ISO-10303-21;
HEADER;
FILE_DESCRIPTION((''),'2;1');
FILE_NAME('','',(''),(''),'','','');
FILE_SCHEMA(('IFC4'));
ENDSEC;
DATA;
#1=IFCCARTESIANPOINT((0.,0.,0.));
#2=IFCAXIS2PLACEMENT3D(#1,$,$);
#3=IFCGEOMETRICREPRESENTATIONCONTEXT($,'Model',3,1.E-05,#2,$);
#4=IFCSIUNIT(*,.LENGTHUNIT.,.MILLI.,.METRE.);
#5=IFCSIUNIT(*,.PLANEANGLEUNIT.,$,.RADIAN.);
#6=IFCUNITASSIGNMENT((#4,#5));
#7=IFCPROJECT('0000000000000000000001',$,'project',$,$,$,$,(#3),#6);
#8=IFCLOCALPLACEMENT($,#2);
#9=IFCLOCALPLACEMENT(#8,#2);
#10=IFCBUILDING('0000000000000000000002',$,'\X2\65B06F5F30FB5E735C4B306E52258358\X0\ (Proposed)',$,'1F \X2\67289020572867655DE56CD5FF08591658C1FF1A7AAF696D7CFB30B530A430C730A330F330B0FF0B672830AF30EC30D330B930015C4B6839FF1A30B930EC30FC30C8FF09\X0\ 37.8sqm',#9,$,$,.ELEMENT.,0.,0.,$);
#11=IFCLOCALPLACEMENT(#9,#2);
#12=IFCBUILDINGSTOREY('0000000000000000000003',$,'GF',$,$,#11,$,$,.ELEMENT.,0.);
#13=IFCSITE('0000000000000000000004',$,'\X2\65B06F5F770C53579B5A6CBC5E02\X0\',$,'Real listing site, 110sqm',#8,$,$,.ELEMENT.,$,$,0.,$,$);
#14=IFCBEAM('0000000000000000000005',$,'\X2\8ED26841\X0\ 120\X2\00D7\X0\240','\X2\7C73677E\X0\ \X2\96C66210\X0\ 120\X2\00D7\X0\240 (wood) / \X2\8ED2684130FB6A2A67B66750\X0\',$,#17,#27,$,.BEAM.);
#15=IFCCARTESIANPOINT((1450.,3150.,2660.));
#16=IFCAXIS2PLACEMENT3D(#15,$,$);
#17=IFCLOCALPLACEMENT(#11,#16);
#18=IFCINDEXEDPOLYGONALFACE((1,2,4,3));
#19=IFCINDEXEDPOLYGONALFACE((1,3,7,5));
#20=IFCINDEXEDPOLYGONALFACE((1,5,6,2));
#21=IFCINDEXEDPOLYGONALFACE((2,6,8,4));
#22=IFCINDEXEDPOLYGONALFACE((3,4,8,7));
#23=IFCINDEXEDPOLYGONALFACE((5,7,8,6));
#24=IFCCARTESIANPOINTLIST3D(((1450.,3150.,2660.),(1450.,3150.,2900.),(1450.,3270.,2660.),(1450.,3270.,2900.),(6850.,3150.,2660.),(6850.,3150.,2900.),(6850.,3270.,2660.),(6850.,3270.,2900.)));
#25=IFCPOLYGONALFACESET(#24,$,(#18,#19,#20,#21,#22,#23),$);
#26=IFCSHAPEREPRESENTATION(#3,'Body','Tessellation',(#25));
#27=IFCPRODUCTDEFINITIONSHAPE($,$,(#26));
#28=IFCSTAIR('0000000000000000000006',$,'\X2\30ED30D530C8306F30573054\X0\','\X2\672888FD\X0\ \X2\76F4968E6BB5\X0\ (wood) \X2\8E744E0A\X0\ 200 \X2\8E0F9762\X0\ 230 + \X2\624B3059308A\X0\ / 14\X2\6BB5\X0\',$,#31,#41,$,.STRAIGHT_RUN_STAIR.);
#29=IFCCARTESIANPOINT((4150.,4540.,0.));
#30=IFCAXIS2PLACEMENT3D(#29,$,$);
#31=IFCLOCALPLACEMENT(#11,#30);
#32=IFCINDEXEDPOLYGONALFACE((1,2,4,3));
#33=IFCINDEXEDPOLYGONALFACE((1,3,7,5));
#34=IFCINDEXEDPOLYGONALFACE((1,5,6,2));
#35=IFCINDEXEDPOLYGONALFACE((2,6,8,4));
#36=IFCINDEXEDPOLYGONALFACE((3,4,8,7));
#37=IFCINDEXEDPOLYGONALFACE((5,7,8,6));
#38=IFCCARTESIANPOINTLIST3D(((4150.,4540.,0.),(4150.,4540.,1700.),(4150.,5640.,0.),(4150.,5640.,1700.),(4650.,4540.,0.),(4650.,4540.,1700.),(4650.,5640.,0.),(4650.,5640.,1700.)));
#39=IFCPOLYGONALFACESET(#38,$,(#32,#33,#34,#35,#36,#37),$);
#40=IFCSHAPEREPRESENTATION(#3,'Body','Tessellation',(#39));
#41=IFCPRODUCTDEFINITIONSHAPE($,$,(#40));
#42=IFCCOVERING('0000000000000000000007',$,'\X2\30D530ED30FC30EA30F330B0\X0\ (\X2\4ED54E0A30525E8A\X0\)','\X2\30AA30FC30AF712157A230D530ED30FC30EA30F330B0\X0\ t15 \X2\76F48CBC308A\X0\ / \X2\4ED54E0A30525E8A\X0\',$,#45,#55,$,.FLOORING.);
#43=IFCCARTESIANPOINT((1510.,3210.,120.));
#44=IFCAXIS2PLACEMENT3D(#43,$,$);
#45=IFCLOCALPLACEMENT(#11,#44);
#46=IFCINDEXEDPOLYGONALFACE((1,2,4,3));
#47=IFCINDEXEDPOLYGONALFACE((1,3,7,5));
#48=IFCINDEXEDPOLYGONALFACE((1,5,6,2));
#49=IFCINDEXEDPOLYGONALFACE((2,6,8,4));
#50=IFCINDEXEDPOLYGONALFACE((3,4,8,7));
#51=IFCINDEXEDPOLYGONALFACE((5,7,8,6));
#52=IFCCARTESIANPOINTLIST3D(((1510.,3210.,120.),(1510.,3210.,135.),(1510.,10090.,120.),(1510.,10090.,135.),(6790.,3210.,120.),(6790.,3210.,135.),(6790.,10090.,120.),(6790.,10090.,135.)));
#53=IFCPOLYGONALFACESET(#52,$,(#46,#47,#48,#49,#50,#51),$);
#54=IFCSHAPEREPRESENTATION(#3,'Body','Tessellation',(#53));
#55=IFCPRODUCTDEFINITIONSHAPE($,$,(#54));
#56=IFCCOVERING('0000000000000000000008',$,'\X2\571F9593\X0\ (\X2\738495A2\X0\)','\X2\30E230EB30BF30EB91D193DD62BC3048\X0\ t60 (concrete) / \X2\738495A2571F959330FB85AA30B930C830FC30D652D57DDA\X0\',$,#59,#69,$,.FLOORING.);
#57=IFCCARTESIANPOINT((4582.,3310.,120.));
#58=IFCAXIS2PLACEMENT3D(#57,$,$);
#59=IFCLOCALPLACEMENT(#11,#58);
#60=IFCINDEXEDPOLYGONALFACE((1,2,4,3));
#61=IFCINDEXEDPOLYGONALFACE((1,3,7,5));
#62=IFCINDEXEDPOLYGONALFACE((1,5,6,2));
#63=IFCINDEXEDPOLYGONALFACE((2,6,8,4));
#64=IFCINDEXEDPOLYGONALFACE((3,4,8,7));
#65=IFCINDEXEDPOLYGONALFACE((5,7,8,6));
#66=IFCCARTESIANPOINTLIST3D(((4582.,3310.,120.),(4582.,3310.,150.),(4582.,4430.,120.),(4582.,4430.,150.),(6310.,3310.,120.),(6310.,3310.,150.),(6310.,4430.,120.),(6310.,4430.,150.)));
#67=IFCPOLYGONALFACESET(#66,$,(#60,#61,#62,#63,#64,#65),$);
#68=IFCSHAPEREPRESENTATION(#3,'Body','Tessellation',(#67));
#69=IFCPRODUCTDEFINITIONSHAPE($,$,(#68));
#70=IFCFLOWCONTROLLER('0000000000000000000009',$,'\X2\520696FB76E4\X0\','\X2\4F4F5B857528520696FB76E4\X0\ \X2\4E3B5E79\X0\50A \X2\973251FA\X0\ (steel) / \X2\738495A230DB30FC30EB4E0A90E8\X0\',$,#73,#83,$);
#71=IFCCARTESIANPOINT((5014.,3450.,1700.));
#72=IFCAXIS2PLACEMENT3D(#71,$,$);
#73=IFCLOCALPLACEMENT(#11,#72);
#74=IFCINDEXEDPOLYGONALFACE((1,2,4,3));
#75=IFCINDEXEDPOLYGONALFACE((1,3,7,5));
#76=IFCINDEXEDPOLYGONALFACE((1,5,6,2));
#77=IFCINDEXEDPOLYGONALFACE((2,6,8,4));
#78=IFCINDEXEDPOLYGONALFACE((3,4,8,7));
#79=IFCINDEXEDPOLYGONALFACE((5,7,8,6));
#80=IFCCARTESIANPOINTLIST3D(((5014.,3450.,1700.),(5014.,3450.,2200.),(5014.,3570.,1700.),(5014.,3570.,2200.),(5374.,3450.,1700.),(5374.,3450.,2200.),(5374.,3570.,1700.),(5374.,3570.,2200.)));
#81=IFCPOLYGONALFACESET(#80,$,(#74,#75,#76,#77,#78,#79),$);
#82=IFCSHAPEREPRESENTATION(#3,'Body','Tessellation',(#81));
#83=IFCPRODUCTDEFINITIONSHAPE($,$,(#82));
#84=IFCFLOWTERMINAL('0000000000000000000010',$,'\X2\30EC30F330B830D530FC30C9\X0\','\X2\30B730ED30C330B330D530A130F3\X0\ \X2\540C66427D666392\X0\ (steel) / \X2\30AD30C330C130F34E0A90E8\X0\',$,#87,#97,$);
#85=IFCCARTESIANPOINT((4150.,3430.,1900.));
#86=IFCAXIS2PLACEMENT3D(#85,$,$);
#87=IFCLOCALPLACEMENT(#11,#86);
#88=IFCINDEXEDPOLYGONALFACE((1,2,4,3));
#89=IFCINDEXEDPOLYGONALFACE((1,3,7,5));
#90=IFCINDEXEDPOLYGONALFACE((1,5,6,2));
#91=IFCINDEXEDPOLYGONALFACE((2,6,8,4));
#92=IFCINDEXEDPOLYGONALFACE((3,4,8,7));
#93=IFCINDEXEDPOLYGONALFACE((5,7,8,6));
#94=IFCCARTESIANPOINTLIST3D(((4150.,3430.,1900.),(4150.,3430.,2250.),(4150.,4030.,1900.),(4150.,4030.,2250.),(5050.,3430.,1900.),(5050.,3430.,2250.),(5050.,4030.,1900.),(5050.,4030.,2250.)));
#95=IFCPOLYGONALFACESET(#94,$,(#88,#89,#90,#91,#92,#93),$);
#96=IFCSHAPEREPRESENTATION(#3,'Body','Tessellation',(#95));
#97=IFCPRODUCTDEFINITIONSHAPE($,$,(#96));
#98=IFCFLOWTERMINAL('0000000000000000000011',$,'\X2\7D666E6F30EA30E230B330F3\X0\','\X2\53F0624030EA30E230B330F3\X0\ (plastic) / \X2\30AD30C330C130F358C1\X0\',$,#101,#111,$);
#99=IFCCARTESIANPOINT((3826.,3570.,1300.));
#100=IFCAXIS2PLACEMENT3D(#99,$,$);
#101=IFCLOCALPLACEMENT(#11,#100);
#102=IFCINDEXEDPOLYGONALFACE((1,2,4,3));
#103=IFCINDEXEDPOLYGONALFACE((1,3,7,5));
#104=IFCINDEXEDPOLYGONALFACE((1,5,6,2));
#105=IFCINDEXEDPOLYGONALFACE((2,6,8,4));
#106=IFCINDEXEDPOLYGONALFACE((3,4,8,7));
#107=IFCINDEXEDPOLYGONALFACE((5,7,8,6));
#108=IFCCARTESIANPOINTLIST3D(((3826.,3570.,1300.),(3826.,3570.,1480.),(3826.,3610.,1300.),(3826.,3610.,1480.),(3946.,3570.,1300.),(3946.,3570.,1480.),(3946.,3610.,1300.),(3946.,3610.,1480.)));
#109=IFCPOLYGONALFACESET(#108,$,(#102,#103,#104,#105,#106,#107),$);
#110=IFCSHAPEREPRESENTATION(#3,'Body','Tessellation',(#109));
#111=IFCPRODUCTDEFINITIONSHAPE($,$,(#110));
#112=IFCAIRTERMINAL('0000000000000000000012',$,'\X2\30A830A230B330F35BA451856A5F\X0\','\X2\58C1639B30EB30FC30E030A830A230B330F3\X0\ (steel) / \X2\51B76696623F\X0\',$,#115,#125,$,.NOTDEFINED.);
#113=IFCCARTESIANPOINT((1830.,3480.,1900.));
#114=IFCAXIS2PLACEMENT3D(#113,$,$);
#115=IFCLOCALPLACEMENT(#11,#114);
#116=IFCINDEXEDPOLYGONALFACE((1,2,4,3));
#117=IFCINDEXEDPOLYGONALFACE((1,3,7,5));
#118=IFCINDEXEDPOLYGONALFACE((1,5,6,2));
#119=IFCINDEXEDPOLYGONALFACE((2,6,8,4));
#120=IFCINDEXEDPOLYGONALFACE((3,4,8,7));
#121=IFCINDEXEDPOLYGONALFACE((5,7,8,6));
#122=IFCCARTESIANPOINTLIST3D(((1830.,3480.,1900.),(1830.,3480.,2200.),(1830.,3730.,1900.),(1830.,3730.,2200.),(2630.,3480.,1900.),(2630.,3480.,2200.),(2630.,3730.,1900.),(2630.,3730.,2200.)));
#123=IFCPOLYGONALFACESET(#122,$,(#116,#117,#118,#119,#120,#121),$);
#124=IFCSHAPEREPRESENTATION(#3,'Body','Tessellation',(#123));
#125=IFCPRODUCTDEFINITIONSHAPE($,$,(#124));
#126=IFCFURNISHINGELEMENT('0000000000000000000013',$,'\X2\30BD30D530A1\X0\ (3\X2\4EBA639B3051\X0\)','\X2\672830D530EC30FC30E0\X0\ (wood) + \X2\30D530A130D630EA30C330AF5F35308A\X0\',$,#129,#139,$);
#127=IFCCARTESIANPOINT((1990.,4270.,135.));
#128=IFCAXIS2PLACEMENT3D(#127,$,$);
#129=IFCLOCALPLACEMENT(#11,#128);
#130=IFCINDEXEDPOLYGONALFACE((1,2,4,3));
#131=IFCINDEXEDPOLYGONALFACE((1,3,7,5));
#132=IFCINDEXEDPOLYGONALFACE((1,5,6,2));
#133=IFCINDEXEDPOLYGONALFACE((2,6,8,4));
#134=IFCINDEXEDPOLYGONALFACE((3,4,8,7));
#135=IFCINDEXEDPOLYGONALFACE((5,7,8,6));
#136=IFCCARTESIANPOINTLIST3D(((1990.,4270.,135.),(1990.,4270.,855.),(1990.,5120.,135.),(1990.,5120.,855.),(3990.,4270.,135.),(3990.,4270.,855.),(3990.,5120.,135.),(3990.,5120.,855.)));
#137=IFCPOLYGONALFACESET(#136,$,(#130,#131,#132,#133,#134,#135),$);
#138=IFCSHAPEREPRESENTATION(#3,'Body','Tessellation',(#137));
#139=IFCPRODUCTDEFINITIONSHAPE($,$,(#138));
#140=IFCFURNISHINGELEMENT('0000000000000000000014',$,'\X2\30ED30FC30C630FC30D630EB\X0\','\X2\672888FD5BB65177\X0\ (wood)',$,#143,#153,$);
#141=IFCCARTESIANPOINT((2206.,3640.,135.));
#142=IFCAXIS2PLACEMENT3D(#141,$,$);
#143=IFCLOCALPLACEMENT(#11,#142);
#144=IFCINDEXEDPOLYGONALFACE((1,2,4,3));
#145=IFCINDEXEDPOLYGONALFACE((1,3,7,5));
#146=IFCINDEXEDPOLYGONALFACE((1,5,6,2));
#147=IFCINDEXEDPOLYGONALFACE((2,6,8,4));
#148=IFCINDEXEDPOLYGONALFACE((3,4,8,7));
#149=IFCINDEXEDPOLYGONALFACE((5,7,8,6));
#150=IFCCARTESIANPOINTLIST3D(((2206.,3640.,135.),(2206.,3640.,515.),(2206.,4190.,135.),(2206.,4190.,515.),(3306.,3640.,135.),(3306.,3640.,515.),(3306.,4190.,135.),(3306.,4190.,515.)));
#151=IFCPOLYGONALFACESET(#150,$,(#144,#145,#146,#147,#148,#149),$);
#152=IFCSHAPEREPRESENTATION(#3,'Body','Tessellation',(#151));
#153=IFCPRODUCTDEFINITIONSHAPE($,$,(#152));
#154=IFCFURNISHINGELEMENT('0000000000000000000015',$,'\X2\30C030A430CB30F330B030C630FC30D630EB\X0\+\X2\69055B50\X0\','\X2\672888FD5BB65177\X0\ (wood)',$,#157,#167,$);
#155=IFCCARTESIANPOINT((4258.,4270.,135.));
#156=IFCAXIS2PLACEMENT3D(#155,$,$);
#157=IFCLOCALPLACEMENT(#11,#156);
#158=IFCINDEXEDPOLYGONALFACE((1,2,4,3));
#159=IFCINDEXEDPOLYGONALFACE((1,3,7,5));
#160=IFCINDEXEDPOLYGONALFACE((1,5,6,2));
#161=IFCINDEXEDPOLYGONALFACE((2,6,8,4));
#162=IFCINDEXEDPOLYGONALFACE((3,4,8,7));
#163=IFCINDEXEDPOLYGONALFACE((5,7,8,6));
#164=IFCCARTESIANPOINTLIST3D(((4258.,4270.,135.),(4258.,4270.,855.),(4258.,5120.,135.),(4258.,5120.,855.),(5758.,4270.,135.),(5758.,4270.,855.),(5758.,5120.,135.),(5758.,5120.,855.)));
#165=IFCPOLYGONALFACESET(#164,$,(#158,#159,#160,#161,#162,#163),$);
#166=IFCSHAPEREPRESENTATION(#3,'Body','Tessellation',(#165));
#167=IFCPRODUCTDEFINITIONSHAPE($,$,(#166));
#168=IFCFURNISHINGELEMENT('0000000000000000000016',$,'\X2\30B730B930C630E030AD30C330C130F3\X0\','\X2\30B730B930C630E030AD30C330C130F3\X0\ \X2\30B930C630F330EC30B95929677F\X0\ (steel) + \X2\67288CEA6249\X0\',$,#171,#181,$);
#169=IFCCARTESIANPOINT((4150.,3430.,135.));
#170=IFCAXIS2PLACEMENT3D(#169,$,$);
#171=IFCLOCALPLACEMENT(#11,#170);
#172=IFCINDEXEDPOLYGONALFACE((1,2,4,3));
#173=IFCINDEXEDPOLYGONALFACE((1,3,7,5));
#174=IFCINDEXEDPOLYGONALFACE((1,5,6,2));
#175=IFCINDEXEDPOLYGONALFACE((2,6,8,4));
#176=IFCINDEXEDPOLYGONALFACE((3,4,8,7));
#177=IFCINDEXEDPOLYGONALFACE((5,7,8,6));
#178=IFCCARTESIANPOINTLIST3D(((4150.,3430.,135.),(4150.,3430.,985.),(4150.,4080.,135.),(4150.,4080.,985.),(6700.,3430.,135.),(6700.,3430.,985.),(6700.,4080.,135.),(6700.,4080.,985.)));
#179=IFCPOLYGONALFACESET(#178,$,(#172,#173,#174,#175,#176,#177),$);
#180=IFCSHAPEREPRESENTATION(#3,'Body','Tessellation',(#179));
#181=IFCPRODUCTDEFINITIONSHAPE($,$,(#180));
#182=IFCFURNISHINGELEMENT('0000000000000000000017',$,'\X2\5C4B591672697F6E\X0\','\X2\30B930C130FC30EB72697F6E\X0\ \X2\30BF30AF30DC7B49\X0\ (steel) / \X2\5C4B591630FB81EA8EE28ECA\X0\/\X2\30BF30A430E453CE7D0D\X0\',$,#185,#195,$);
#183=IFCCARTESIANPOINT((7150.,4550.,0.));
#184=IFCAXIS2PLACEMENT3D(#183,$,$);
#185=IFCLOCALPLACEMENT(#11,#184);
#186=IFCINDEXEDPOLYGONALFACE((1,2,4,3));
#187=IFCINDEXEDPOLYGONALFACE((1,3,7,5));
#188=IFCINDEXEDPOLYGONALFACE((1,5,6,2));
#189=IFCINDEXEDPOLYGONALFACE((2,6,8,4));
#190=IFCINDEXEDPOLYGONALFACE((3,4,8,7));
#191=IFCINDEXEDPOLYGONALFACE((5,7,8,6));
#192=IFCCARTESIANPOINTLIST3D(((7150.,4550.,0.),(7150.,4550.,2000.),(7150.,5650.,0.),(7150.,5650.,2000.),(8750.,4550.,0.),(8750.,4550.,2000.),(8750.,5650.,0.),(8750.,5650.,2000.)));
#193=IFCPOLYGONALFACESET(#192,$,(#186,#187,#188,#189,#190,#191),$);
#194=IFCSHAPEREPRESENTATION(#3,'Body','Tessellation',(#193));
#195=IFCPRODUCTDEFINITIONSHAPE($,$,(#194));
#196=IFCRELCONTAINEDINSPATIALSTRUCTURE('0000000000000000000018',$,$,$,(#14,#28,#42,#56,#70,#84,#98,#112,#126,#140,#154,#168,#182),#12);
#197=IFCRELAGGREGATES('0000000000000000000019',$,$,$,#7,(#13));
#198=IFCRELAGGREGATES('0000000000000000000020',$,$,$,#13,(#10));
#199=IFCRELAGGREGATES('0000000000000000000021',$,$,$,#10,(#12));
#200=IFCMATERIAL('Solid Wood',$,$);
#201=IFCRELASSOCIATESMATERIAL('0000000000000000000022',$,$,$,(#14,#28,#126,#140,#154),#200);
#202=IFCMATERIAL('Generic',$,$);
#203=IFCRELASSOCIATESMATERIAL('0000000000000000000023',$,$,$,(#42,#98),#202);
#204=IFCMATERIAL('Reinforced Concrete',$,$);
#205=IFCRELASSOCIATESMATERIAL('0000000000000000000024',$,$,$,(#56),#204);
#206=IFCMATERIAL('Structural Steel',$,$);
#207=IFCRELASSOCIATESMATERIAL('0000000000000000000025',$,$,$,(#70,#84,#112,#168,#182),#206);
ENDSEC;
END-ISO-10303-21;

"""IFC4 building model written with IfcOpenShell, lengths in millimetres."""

from ifc_helpers import new_model, si_unit, frame, frame_2d, origin, place, context, project, spatial, rectangle, extrude, material, element, save


model = new_model("IFC4")

# Units and contexts
model_context = context("Model", 3, precision=1e-05, world=origin())
ifc_project = project(units=[si_unit("LENGTHUNIT", "METRE", prefix="MILLI"), si_unit("PLANEANGLEUNIT", "RADIAN")], contexts=[model_context])

# Site, building, storey
site_placement = place(None, origin())
site = spatial("IfcSite", under=ifc_project, at=site_placement, Name="新潟県南魚沼市", ObjectType="Real listing site, 110sqm", CompositionType="ELEMENT", RefElevation=0.0)
building_placement = place(site_placement, origin())
building = spatial("IfcBuilding", under=site, at=building_placement, Name="新潟・平屋の別荘 (Proposed)", ObjectType="1F 木造在来工法（外壁：窯業系サイディング＋木クレビス、屋根：スレート） 37.8sqm", CompositionType="ELEMENT", ElevationOfRefHeight=0.0, ElevationOfTerrain=0.0)
storey_placement = place(building_placement, origin())
storey = spatial("IfcBuildingStorey", under=building, at=storey_placement, Name="GF", CompositionType="ELEMENT", Elevation=0.0)

# Beam
ifc_material_1 = material(Name="Solid Wood")
beam_1_placement = place(storey_placement, frame((1450.0, 3150.0, 2660.0)))
element("IfcBeam", 1, at=beam_1_placement, inside=storey, material=ifc_material_1, Name="軒桁 120×240", Description="米松 集成 120×240 (wood) / 軒桁・横架材", PredefinedType="BEAM", context=model_context, shape_type="SweptSolid", body=[
    extrude(rectangle(XDim=5400.0, YDim=120.0, at=frame_2d((2700.0, 60.0))), frame((1450.0, 3150.0, 2660.0)), (0.0, 0.0, 1.0), 240.0),
])

# Stair
stair_placement = place(storey_placement, frame((4150.0, 4540.0, 0.0)))
element("IfcStair", 2, at=stair_placement, inside=storey, material=ifc_material_1, Name="ロフトはしご", Description="木製 直階段 (wood) 蹴上 200 踏面 230 + 手すり / 14段", PredefinedType="STRAIGHT_RUN_STAIR", context=model_context, shape_type="SweptSolid", body=[
    extrude(rectangle(XDim=500.0, YDim=1100.0, at=frame_2d((250.0, 550.0))), frame((4150.0, 4540.0, 0.0)), (0.0, 0.0, 1.0), 1700.0),
])

# Coverings
ifc_material_2 = material(Name="Generic")
covering_1_placement = place(storey_placement, frame((1510.0, 3210.0, 120.0)))
element("IfcCovering", 3, at=covering_1_placement, inside=storey, material=ifc_material_2, Name="フローリング (仕上げ床)", Description="オーク無垢フローリング t15 直貼り / 仕上げ床", PredefinedType="FLOORING", context=model_context, shape_type="SweptSolid", body=[
    extrude(rectangle(XDim=5280.0, YDim=6880.0, at=frame_2d((2640.0, 3440.0))), frame((1510.0, 3210.0, 120.0)), (0.0, 0.0, 1.0), 15.0),
])
ifc_material_3 = material(Name="Reinforced Concrete")
covering_2_placement = place(storey_placement, frame((4582.0, 3310.0, 120.0)))
element("IfcCovering", 4, at=covering_2_placement, inside=storey, material=ifc_material_3, Name="土間 (玄関)", Description="モルタル金鏝押え t60 (concrete) / 玄関土間・薪ストーブ動線", PredefinedType="FLOORING", context=model_context, shape_type="SweptSolid", body=[
    extrude(rectangle(XDim=1728.0, YDim=1120.0, at=frame_2d((864.0, 560.0))), frame((4582.0, 3310.0, 120.0)), (0.0, 0.0, 1.0), 30.0),
])

# Flow controller
ifc_material_4 = material(Name="Structural Steel")
flow_controller_placement = place(storey_placement, frame((5014.0, 3450.0, 1700.0)))
element("IfcFlowController", 5, at=flow_controller_placement, inside=storey, material=ifc_material_4, Name="分電盤", Description="住宅用分電盤 主幹50A 露出 (steel) / 玄関ホール上部", context=model_context, shape_type="SweptSolid", body=[
    extrude(rectangle(XDim=360.0, YDim=120.0, at=frame_2d((180.0, 60.0))), frame((5014.0, 3450.0, 1700.0)), (0.0, 0.0, 1.0), 500.0),
])

# Flow terminals
flow_terminal_1_placement = place(storey_placement, frame((4150.0, 3430.0, 1900.0)))
element("IfcFlowTerminal", 6, at=flow_terminal_1_placement, inside=storey, material=ifc_material_4, Name="レンジフード", Description="シロッコファン 同時給排 (steel) / キッチン上部", context=model_context, shape_type="SweptSolid", body=[
    extrude(rectangle(XDim=900.0, YDim=600.0, at=frame_2d((450.0, 300.0))), frame((4150.0, 3430.0, 1900.0)), (0.0, 0.0, 1.0), 350.0),
])
flow_terminal_2_placement = place(storey_placement, frame((3826.0, 3570.0, 1300.0)))
element("IfcFlowTerminal", 7, at=flow_terminal_2_placement, inside=storey, material=ifc_material_2, Name="給湯リモコン", Description="台所リモコン (plastic) / キッチン壁", context=model_context, shape_type="SweptSolid", body=[
    extrude(rectangle(XDim=120.0, YDim=40.0, at=frame_2d((60.0, 20.0))), frame((3826.0, 3570.0, 1300.0)), (0.0, 0.0, 1.0), 180.0),
])

# Air terminal
air_terminal_placement = place(storey_placement, frame((1830.0, 3480.0, 1900.0)))
element("IfcAirTerminal", 8, at=air_terminal_placement, inside=storey, material=ifc_material_4, Name="エアコン室内機", Description="壁掛ルームエアコン (steel) / 冷暖房", PredefinedType="NOTDEFINED", context=model_context, shape_type="SweptSolid", body=[
    extrude(rectangle(XDim=800.0, YDim=250.0, at=frame_2d((400.0, 125.0))), frame((1830.0, 3480.0, 1900.0)), (0.0, 0.0, 1.0), 300.0),
])

# Furnishing elements
furnishing_1_placement = place(storey_placement, frame((1990.0, 4270.0, 135.0)))
element("IfcFurnishingElement", 9, at=furnishing_1_placement, inside=storey, material=ifc_material_1, Name="ソファ (3人掛け)", Description="木フレーム (wood) + ファブリック張り", context=model_context, shape_type="SweptSolid", body=[
    extrude(rectangle(XDim=2000.0, YDim=850.0, at=frame_2d((1000.0, 425.0))), frame((1990.0, 4270.0, 135.0)), (0.0, 0.0, 1.0), 720.0),
])
furnishing_2_placement = place(storey_placement, frame((2206.0, 3640.0, 135.0)))
element("IfcFurnishingElement", 10, at=furnishing_2_placement, inside=storey, material=ifc_material_1, Name="ローテーブル", Description="木製家具 (wood)", context=model_context, shape_type="SweptSolid", body=[
    extrude(rectangle(XDim=1100.0, YDim=550.0, at=frame_2d((550.0, 275.0))), frame((2206.0, 3640.0, 135.0)), (0.0, 0.0, 1.0), 380.0),
])
furnishing_3_placement = place(storey_placement, frame((4258.0, 4270.0, 135.0)))
element("IfcFurnishingElement", 11, at=furnishing_3_placement, inside=storey, material=ifc_material_1, Name="ダイニングテーブル+椅子", Description="木製家具 (wood)", context=model_context, shape_type="SweptSolid", body=[
    extrude(rectangle(XDim=1500.0, YDim=850.0, at=frame_2d((750.0, 425.0))), frame((4258.0, 4270.0, 135.0)), (0.0, 0.0, 1.0), 720.0),
])
furnishing_4_placement = place(storey_placement, frame((4150.0, 3430.0, 135.0)))
element("IfcFurnishingElement", 12, at=furnishing_4_placement, inside=storey, material=ifc_material_4, Name="システムキッチン", Description="システムキッチン ステンレス天板 (steel) + 木質扉", context=model_context, shape_type="SweptSolid", body=[
    extrude(rectangle(XDim=2550.0, YDim=650.0, at=frame_2d((1275.0, 325.0))), frame((4150.0, 3430.0, 135.0)), (0.0, 0.0, 1.0), 850.0),
])
furnishing_5_placement = place(storey_placement, frame((7150.0, 4550.0, 0.0)))
element("IfcFurnishingElement", 13, at=furnishing_5_placement, inside=storey, material=ifc_material_4, Name="屋外物置", Description="スチール物置 タクボ等 (steel) / 屋外・自転車/タイヤ収納", context=model_context, shape_type="SweptSolid", body=[
    extrude(rectangle(XDim=1600.0, YDim=1100.0, at=frame_2d((800.0, 550.0))), frame((7150.0, 4550.0, 0.0)), (0.0, 0.0, 1.0), 2000.0),
])

save(model, "model.ifc")
